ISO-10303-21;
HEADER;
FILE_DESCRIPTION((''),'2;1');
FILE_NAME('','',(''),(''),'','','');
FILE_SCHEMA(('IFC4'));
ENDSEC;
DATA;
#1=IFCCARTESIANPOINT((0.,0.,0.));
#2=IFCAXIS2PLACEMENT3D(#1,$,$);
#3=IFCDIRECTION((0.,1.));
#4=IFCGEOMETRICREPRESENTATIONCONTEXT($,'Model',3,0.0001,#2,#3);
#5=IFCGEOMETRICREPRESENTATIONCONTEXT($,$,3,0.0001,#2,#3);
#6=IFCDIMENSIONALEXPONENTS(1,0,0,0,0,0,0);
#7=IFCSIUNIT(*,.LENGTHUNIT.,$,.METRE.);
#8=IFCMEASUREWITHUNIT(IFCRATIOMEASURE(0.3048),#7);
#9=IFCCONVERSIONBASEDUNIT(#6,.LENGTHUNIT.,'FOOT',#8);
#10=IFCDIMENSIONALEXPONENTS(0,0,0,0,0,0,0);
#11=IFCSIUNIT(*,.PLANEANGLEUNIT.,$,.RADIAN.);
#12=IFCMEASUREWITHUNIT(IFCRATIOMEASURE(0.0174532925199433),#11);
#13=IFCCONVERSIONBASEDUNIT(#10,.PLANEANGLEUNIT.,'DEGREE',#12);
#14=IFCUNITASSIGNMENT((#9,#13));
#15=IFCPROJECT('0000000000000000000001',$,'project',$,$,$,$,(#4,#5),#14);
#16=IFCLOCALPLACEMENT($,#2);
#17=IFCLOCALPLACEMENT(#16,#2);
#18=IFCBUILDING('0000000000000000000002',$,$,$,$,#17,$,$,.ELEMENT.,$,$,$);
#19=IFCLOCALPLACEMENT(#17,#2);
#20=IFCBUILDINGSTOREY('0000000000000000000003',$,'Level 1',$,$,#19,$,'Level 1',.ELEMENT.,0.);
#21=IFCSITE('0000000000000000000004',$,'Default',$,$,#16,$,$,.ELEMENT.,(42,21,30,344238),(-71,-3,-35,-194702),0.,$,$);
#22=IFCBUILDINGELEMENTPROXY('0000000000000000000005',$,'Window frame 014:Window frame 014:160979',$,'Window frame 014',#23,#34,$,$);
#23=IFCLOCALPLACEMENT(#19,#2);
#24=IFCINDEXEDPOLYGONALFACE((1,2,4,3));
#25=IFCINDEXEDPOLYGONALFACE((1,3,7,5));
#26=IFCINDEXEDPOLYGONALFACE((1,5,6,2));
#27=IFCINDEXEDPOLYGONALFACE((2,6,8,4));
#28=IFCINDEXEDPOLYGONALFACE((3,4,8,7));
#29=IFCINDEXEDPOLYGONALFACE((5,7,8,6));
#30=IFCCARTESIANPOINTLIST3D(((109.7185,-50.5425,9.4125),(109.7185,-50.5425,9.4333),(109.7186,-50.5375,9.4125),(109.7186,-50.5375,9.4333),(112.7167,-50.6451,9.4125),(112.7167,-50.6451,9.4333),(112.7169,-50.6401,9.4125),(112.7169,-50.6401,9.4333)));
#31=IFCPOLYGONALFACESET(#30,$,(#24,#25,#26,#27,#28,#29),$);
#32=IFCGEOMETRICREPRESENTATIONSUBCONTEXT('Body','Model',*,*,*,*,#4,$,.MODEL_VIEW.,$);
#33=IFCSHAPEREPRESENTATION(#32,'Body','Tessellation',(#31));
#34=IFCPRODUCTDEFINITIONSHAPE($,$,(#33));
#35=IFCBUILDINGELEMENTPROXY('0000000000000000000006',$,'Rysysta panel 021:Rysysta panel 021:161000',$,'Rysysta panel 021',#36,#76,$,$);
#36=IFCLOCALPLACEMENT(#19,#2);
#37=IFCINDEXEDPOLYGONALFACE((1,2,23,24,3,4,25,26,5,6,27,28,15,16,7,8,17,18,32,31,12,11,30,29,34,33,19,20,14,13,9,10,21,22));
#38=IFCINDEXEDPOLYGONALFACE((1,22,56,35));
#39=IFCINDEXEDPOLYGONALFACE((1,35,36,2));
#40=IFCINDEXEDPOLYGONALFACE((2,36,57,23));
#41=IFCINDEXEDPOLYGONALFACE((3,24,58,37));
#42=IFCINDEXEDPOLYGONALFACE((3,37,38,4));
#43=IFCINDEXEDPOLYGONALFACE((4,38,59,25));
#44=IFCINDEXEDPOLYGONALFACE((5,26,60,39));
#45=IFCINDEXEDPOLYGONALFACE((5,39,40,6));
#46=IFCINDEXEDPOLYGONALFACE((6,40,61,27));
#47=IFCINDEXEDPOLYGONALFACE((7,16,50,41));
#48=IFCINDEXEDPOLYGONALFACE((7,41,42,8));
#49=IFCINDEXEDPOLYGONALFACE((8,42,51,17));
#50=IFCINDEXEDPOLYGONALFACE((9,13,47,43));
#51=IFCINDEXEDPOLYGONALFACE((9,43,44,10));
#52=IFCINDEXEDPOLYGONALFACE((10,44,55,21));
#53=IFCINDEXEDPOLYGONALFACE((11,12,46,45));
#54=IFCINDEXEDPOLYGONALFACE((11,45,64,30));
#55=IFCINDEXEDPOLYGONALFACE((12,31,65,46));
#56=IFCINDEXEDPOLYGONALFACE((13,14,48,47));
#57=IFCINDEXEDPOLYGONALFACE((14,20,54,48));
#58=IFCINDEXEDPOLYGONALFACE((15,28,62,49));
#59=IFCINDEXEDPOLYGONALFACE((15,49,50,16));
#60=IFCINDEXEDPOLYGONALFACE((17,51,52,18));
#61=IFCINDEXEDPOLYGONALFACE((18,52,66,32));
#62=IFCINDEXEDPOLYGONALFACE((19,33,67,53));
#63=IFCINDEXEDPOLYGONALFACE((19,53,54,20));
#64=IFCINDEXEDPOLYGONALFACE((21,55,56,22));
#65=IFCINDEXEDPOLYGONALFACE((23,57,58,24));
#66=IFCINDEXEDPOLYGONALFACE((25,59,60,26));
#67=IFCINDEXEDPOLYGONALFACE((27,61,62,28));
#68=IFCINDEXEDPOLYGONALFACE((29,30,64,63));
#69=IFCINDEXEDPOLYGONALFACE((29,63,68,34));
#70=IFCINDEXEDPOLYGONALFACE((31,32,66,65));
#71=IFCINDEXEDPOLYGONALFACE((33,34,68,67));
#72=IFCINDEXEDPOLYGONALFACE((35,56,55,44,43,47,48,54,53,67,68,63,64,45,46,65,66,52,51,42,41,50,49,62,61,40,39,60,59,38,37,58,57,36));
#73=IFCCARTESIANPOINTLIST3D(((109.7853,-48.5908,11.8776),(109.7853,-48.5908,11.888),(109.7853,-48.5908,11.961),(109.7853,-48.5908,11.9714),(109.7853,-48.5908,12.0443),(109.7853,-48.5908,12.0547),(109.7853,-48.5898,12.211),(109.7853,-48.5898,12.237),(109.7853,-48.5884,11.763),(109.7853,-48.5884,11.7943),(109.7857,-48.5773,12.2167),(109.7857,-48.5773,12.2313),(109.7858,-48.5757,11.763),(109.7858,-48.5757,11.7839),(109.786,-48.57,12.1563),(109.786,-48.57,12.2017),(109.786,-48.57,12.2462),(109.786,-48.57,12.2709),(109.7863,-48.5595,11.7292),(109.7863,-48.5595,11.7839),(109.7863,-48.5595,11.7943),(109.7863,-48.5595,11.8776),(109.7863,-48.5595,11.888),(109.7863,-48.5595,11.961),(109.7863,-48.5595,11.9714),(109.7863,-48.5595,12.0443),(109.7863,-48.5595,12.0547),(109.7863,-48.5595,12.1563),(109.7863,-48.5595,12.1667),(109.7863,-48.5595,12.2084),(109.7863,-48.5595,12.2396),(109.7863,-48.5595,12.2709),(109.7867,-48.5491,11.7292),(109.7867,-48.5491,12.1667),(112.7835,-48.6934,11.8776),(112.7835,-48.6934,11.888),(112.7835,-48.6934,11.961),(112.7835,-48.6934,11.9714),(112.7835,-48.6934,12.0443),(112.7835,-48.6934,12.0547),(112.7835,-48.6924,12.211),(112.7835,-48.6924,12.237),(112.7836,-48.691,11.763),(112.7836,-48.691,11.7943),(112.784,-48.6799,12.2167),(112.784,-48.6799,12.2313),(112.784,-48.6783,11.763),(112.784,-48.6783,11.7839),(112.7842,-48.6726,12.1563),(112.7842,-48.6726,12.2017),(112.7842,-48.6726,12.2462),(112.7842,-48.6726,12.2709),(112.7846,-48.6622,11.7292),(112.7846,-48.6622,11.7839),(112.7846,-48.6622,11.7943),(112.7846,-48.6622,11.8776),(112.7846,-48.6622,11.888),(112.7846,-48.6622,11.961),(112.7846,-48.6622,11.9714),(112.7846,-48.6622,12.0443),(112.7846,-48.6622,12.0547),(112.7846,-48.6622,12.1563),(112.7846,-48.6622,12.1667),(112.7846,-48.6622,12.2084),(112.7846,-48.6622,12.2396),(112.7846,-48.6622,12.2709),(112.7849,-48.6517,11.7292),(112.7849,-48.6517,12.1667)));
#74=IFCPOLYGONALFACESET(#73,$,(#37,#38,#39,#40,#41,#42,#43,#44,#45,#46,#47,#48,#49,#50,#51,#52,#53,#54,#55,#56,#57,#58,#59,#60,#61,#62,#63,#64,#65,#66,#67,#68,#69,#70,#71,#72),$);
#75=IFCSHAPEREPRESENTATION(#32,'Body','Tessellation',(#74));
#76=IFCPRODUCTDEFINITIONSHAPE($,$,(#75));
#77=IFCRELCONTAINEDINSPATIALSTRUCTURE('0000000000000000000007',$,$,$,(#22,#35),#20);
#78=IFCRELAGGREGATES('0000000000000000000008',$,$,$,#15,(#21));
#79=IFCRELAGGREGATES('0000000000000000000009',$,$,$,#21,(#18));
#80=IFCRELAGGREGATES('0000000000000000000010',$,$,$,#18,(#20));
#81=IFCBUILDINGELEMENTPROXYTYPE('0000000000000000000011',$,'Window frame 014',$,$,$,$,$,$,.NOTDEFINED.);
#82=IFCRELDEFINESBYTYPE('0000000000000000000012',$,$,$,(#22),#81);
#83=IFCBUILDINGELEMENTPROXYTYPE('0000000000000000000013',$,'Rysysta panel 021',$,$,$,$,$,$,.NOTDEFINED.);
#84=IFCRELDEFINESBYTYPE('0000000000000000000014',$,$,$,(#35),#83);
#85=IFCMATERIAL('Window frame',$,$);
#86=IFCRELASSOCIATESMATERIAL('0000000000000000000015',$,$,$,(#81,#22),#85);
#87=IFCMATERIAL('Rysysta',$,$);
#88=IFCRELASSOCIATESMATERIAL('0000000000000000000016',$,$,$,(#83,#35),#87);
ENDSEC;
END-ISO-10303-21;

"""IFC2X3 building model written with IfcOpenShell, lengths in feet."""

from ifc_helpers import new_model, entity, si_unit, converted_unit, direction, frame, frame_2d, origin, place, context, subcontext, project, spatial, polyline, rectangle, outline, extrude, source, transform, mapped, material, type_object, type_shapes, element, save


model = new_model("IFC2X3")

# Units and contexts
model_context = context("Model", 3, precision=0.0001, world=origin(), true_north=direction((0.0, 1.0)))
context_of_model = context(None, 3, precision=0.0001, world=origin(), true_north=direction((0.0, 1.0)))
body_context = subcontext(model_context, "Body", "Model", "MODEL_VIEW")
ifc_project = project(units=[converted_unit("LENGTHUNIT", "FOOT", entity("IfcRatioMeasure", 0.3048), si_unit("LENGTHUNIT", "METRE"), dimensions=[1, 0, 0, 0, 0, 0, 0]), converted_unit("PLANEANGLEUNIT", "DEGREE", entity("IfcRatioMeasure", 0.0174532925199433), si_unit("PLANEANGLEUNIT", "RADIAN"), dimensions=[0, 0, 0, 0, 0, 0, 0])], contexts=[model_context, context_of_model])

# Site, building, storey
site_placement = place(None, origin())
site = spatial("IfcSite", under=ifc_project, at=site_placement, Name="Default", CompositionType="ELEMENT", RefLatitude=(42, 21, 30, 344238), RefLongitude=(-71, -3, -35, -194702), RefElevation=0.0)
building_placement = place(site_placement, origin())
building = spatial("IfcBuilding", under=site, at=building_placement, CompositionType="ELEMENT")
storey_placement = place(building_placement, origin())
storey = spatial("IfcBuildingStorey", under=building, at=storey_placement, Name="Level 1", LongName="Level 1", CompositionType="ELEMENT", Elevation=0.0)

# Building element proxies
ifc_material_1 = material(Name="Window frame")
building_element_proxy_type_1 = type_object("IfcBuildingElementProxyType", Name="Window frame 014", PredefinedType="NOTDEFINED", material=ifc_material_1)
shared_shape_1 = source(origin(), body_context, "Body", "SweptSolid", [
    extrude(rectangle(XDim=3.0, YDim=0.005, at=frame_2d((0.0, 0.0), x_axis=(1.0, 0.0))), frame((111.2177, -50.5913, 9.4125), z_axis=(0.0, 0.0, 1.0), x_axis=(-0.999415, 0.034202, 0.0)), (0.0, 0.0, 1.0), 0.0208),
])
type_shapes(building_element_proxy_type_1, [shared_shape_1])
proxy_1_placement = place(storey_placement, origin())
element("IfcBuildingElementProxy", 1, at=proxy_1_placement, inside=storey, type_object=building_element_proxy_type_1, material=ifc_material_1, Name="Window frame 014:Window frame 014:160979", ObjectType="Window frame 014", context=body_context, shape_type="MappedRepresentation", body=[
    mapped(shared_shape_1, transform((0.0, 0.0, 0.0), scale=1.0)),
])
ifc_material_2 = material(Name="Rysysta")
building_element_proxy_type_2 = type_object("IfcBuildingElementProxyType", Name="Rysysta panel 021", PredefinedType="NOTDEFINED", material=ifc_material_2)
shared_shape_2 = source(origin(), body_context, "Body", "SweptSolid", [
    extrude(outline(polyline([(-0.022, 0.1457), (-0.022, -0.2918), (-0.0116, -0.2918), (-0.0116, -0.2371), (0.0045, -0.2371), (0.0045, -0.258), (0.0173, -0.258), (0.0173, -0.2267), (-0.0116, -0.2267), (-0.0116, -0.1434), (0.0196, -0.1434), (0.0196, -0.133), (-0.0116, -0.133), (-0.0116, -0.06), (0.0196, -0.06), (0.0196, -0.0496), (-0.0116, -0.0496), (-0.0116, 0.0233), (0.0196, 0.0233), (0.0196, 0.0337), (-0.0116, 0.0337), (-0.0116, 0.1353), (-0.0012, 0.1353), (-0.0012, 0.1807), (0.0186, 0.1899), (0.0186, 0.216), (-0.0012, 0.2252), (-0.0012, 0.2498), (-0.0116, 0.2498), (-0.0116, 0.2186), (0.0062, 0.2103), (0.0062, 0.1956), (-0.0116, 0.1873), (-0.0116, 0.1457), (-0.022, 0.1457)])), frame((109.7859, -48.5711, 12.021), z_axis=(-0.999415, 0.034202, 0.0), x_axis=(-0.034202, -0.999415, 0.0)), (0.0, 0.0, -1.0), 3.0),
])
type_shapes(building_element_proxy_type_2, [shared_shape_2])
proxy_2_placement = place(storey_placement, origin())
element("IfcBuildingElementProxy", 2, at=proxy_2_placement, inside=storey, type_object=building_element_proxy_type_2, material=ifc_material_2, Name="Rysysta panel 021:Rysysta panel 021:161000", ObjectType="Rysysta panel 021", context=body_context, shape_type="MappedRepresentation", body=[
    mapped(shared_shape_2, transform((0.0, 0.0, 0.0), scale=1.0)),
])

save(model, "model.ifc")
